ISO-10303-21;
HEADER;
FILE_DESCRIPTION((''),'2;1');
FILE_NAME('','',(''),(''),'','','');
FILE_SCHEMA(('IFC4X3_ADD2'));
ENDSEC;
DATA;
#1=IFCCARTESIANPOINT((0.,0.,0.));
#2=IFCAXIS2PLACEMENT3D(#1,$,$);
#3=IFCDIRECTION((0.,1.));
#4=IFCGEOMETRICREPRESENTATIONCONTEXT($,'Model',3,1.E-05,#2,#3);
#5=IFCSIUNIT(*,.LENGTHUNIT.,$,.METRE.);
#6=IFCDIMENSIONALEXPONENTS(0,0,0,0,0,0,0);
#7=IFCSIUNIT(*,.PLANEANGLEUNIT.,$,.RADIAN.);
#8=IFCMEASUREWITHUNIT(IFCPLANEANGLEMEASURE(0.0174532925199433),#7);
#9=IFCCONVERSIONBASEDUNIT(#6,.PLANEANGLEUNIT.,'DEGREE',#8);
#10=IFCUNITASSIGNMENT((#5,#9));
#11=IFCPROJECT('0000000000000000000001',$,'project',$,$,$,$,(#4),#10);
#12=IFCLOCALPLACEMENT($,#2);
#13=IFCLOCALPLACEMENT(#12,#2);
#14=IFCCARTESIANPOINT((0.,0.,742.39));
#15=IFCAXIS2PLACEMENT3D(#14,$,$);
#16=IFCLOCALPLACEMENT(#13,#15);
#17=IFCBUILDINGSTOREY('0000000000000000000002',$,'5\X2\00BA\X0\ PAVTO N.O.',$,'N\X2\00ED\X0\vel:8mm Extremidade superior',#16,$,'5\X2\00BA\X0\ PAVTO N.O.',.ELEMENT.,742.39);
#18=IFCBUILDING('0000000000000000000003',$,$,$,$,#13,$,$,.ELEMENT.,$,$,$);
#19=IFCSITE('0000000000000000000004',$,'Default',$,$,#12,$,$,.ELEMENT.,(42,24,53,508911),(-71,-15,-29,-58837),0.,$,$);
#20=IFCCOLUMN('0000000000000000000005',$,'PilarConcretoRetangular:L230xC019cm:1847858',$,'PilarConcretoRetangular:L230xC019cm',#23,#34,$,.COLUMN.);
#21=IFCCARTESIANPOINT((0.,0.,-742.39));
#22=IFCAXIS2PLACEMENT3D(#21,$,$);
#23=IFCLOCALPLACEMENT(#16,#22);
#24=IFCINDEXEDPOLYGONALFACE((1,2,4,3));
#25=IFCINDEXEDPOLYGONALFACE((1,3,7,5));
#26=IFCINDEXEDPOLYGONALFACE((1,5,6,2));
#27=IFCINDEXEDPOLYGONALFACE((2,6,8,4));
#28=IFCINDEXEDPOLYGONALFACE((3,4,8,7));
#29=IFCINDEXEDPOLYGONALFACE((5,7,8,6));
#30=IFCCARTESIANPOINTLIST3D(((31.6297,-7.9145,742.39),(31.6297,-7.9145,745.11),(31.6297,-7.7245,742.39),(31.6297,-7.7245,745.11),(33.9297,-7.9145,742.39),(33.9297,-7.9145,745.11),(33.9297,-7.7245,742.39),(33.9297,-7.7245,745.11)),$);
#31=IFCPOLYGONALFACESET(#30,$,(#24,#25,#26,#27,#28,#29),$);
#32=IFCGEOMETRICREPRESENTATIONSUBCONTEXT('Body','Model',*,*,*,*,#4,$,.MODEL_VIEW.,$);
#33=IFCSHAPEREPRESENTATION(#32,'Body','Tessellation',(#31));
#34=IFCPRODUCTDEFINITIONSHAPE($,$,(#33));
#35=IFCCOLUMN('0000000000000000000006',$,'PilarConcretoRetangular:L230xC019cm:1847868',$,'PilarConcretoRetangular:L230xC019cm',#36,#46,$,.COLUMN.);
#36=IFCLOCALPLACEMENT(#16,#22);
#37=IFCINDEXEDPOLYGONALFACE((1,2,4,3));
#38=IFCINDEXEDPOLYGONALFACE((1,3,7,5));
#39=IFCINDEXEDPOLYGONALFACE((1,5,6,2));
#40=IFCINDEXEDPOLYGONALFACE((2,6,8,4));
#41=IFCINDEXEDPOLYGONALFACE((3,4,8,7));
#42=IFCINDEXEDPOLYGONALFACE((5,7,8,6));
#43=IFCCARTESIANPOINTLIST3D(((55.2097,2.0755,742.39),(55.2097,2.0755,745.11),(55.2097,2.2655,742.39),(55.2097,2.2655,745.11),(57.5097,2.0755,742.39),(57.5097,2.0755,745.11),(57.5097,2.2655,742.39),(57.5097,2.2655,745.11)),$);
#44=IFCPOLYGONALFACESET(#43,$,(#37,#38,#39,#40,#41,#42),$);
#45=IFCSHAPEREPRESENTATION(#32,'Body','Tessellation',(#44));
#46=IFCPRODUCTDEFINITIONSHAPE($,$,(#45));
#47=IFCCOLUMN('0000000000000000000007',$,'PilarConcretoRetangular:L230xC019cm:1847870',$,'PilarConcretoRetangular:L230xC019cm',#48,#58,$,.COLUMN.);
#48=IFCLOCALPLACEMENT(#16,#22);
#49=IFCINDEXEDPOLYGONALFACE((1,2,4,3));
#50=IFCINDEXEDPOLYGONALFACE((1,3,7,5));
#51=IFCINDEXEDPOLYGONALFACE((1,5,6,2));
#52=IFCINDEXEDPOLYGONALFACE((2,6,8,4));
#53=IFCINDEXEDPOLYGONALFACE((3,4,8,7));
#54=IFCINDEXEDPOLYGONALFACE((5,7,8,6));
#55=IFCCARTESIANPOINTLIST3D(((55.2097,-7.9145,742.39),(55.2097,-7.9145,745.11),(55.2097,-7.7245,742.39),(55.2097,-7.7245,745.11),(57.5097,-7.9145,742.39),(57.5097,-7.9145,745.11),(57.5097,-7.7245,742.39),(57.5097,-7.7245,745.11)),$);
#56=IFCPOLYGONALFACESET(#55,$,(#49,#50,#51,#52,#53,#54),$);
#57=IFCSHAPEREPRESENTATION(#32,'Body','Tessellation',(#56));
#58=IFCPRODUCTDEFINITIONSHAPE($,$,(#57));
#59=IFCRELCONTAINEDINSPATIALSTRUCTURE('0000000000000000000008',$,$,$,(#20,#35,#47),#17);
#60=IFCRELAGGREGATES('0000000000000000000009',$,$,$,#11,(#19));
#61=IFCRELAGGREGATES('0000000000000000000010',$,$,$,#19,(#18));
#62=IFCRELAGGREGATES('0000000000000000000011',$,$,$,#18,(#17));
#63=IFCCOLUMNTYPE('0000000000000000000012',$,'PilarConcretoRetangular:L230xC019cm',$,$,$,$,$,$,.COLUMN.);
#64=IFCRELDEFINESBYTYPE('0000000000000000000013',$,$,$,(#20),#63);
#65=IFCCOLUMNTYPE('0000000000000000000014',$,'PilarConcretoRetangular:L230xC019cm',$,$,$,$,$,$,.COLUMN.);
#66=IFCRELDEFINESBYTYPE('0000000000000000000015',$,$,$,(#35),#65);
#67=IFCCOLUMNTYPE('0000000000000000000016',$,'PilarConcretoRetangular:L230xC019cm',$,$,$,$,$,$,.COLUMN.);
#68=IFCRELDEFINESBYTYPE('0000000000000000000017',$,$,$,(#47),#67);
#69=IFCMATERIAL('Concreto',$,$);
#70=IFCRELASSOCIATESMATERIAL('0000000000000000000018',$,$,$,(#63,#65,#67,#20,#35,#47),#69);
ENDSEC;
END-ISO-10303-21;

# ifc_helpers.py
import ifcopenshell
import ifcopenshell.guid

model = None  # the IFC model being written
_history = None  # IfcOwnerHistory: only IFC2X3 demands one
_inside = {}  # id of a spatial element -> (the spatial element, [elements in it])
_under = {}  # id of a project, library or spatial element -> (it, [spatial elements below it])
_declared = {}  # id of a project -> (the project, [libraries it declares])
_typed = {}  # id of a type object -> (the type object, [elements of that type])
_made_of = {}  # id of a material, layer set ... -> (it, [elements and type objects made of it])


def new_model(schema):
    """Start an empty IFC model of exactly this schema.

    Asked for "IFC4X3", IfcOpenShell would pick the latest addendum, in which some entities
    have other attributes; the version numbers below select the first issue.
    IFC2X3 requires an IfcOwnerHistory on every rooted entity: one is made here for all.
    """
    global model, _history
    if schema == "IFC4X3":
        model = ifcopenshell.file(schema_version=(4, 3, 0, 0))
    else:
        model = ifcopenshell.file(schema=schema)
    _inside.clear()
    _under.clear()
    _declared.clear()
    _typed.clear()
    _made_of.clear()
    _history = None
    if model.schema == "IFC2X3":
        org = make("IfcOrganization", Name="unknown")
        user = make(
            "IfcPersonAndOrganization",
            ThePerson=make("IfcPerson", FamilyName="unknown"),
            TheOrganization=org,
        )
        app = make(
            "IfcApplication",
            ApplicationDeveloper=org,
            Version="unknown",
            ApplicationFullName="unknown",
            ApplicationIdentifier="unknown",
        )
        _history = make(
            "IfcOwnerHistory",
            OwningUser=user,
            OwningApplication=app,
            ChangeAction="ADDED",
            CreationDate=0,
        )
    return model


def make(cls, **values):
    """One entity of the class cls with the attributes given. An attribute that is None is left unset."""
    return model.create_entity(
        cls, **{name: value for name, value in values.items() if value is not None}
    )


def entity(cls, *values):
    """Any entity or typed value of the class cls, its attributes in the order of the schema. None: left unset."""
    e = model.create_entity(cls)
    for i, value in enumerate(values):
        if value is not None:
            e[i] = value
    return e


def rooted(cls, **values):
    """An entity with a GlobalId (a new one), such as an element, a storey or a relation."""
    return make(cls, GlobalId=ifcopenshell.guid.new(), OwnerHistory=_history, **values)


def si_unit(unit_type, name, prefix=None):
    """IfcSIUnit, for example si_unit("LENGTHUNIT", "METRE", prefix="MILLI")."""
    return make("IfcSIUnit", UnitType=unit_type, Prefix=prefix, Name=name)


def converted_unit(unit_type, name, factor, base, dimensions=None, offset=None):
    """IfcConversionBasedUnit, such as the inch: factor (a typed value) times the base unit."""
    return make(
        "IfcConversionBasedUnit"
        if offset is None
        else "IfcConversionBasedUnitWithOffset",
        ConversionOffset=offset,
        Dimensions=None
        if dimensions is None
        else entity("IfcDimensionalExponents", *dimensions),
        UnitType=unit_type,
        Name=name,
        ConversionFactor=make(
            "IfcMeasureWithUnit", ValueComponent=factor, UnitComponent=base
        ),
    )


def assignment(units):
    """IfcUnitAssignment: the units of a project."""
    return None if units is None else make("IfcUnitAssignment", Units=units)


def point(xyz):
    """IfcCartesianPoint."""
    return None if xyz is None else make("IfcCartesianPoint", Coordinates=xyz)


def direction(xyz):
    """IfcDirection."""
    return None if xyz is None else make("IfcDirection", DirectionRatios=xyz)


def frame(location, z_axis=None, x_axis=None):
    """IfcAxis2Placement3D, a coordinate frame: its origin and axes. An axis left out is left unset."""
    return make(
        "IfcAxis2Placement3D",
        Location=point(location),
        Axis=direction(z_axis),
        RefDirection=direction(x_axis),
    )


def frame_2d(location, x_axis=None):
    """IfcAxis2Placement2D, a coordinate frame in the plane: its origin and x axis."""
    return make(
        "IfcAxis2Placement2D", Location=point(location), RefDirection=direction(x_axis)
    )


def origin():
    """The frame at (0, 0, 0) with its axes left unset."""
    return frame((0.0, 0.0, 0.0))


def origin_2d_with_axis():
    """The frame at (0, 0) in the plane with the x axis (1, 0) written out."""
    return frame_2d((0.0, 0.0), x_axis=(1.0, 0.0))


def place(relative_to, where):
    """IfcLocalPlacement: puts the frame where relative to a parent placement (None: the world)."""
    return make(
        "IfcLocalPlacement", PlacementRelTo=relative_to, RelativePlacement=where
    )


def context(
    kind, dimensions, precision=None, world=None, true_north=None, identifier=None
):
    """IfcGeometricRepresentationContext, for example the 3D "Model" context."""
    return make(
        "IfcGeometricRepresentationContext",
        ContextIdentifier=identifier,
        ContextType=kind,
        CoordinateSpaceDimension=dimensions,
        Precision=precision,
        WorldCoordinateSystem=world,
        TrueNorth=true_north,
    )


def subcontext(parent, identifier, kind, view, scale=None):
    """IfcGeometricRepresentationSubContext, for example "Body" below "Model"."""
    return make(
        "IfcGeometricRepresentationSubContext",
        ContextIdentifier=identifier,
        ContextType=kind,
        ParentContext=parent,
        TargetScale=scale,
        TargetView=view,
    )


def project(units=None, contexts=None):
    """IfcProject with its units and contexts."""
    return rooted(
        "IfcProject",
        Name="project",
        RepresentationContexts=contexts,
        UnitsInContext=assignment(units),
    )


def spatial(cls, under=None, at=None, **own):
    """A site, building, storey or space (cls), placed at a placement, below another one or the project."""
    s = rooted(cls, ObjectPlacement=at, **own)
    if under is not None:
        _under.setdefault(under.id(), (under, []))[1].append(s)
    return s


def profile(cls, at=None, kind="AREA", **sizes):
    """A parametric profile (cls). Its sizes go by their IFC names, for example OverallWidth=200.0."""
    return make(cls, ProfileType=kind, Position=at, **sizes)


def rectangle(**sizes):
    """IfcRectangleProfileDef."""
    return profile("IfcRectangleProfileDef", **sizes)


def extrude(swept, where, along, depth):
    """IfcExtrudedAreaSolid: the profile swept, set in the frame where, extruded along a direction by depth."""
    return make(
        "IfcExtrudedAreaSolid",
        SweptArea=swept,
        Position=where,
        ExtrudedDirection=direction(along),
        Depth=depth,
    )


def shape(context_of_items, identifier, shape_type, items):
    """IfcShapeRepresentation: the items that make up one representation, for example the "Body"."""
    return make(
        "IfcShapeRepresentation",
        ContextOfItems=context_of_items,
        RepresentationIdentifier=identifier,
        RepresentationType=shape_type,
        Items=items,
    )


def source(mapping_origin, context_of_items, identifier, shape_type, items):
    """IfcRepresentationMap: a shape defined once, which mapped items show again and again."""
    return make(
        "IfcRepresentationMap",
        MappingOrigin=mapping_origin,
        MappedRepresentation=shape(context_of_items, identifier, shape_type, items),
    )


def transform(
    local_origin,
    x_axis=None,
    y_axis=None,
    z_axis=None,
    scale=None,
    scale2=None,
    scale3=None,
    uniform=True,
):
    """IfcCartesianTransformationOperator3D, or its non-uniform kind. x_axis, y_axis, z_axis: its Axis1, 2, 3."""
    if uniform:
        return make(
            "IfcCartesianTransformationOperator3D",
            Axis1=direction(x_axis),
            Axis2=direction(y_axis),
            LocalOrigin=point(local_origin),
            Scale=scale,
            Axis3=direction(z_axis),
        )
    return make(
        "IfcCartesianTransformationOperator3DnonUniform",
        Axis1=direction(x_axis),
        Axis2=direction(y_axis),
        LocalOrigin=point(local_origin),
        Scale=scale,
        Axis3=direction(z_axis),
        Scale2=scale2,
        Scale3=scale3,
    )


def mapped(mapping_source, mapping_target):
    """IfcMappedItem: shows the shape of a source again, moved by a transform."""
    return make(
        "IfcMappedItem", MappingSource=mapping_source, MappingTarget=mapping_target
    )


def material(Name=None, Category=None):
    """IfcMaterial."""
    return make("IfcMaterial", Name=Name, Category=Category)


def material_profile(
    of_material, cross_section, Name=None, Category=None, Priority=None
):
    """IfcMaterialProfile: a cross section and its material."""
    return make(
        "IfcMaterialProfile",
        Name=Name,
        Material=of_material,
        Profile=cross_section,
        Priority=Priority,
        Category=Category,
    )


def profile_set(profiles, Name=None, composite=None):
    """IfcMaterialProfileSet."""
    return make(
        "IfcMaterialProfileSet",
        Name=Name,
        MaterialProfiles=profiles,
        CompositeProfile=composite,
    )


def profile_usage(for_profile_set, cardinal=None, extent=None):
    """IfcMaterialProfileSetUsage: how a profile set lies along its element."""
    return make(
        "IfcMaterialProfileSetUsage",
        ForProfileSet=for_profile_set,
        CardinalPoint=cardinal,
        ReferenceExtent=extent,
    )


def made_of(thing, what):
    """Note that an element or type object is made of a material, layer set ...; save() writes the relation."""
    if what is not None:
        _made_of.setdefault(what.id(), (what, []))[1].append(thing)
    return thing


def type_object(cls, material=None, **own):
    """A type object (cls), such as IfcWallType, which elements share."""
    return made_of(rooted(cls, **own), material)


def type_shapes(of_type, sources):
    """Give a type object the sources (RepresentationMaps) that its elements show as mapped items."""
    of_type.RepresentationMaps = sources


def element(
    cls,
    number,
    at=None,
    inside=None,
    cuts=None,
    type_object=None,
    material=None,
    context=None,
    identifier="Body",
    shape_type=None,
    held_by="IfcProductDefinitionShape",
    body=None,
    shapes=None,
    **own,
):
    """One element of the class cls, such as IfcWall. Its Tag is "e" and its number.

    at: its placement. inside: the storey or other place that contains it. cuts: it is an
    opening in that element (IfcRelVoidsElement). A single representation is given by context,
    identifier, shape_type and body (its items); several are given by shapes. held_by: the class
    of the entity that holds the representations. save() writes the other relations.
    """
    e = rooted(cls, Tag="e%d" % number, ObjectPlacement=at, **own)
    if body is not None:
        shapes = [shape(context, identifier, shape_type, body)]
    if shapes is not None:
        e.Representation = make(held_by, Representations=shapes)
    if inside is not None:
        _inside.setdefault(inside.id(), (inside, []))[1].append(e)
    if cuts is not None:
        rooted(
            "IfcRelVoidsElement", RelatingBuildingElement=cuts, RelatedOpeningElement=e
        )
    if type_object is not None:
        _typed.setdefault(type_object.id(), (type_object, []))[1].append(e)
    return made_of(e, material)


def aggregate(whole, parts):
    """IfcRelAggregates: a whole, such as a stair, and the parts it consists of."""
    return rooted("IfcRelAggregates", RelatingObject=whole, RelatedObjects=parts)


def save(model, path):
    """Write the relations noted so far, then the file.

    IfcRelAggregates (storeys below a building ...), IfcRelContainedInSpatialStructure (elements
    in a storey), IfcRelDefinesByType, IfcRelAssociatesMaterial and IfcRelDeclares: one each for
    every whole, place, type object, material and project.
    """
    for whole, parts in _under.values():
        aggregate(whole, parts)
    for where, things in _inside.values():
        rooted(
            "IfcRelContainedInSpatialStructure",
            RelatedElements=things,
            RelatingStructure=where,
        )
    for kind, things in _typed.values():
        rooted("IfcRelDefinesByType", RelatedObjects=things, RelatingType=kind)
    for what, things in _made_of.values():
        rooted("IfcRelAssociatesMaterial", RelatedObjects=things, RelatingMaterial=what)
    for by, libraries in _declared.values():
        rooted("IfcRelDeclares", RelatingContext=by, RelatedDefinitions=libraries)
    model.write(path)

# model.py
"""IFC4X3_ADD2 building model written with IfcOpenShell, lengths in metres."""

from ifc_helpers import new_model, entity, si_unit, converted_unit, direction, frame, frame_2d, origin, origin_2d_with_axis, place, context, subcontext, project, spatial, rectangle, extrude, source, transform, mapped, material, material_profile, profile_set, profile_usage, type_object, type_shapes, element, save


model = new_model("IFC4X3_ADD2")

# Units and contexts
model_context = context("Model", 3, precision=1e-05, world=origin(), true_north=direction((0.0, 1.0)))
body_context = subcontext(model_context, "Body", "Model", "MODEL_VIEW")
ifc_project = project(units=[si_unit("LENGTHUNIT", "METRE"), converted_unit("PLANEANGLEUNIT", "DEGREE", entity("IfcPlaneAngleMeasure", 0.0174532925199433), si_unit("PLANEANGLEUNIT", "RADIAN"), dimensions=[0, 0, 0, 0, 0, 0, 0])], contexts=[model_context])

# Site, building, storey
site_placement = place(None, origin())
site = spatial("IfcSite", under=ifc_project, at=site_placement, Name="Default", CompositionType="ELEMENT", RefLatitude=(42, 24, 53, 508911), RefLongitude=(-71, -15, -29, -58837), RefElevation=0.0)
building_placement = place(site_placement, origin())
building = spatial("IfcBuilding", under=site, at=building_placement, CompositionType="ELEMENT")
storey_placement = place(building_placement, frame((0.0, 0.0, 742.39)))
storey = spatial("IfcBuildingStorey", under=building, at=storey_placement, Name="5º PAVTO N.O.", ObjectType="Nível:8mm Extremidade superior", LongName="5º PAVTO N.O.", CompositionType="ELEMENT", Elevation=742.39)

# Columns
ifc_material = material(Name="Concreto")
ifc_material_profile_1 = material_profile(ifc_material, rectangle(XDim=2.3, YDim=0.19, at=frame_2d((0.192, 0.019), x_axis=(1.0, 0.0))), Name="L230xC019cm")
ifc_profile_set_1 = profile_set([ifc_material_profile_1], Name="L230xC019cm")
ifc_profile_usage_1 = profile_usage(ifc_profile_set_1)
column_type_1 = type_object("IfcColumnType", Name="PilarConcretoRetangular:L230xC019cm", PredefinedType="COLUMN", material=ifc_profile_set_1)
shared_shape_1 = source(origin(), body_context, "Body", "SweptSolid", [
    extrude(rectangle(XDim=2.3, YDim=0.19, at=frame_2d((0.0, 0.0), x_axis=(1.0, 0.0))), frame((32.7797, -7.8195, 742.39)), (0.0, 0.0, 1.0), 2.72),
])
type_shapes(column_type_1, [shared_shape_1])
column_1_placement = place(storey_placement, frame((0.0, 0.0, -742.39)))
element("IfcColumn", 1, at=column_1_placement, inside=storey, type_object=column_type_1, material=ifc_profile_usage_1, Name="PilarConcretoRetangular:L230xC019cm:1847858", ObjectType="PilarConcretoRetangular:L230xC019cm", PredefinedType="COLUMN", context=body_context, shape_type="MappedRepresentation", body=[
    mapped(shared_shape_1, transform((0.0, 0.0, 0.0), scale=1.0)),
])
column_type_2 = type_object("IfcColumnType", Name="PilarConcretoRetangular:L230xC019cm", PredefinedType="COLUMN", material=ifc_profile_set_1)
shared_shape_2 = source(origin(), body_context, "Body", "SweptSolid", [
    extrude(rectangle(XDim=2.3, YDim=0.19, at=origin_2d_with_axis()), frame((56.3597, 2.1705, 742.39), z_axis=(0.0, 0.0, 1.0), x_axis=(-1.0, 0.0, 0.0)), (0.0, 0.0, 1.0), 2.72),
])
type_shapes(column_type_2, [shared_shape_2])
column_2_placement = place(storey_placement, frame((0.0, 0.0, -742.39)))
element("IfcColumn", 2, at=column_2_placement, inside=storey, type_object=column_type_2, material=ifc_profile_usage_1, Name="PilarConcretoRetangular:L230xC019cm:1847868", ObjectType="PilarConcretoRetangular:L230xC019cm", PredefinedType="COLUMN", context=body_context, shape_type="MappedRepresentation", body=[
    mapped(shared_shape_2, transform((0.0, 0.0, 0.0), scale=1.0)),
])
column_type_3 = type_object("IfcColumnType", Name="PilarConcretoRetangular:L230xC019cm", PredefinedType="COLUMN", material=ifc_profile_set_1)
shared_shape_3 = source(origin(), body_context, "Body", "SweptSolid", [
    extrude(rectangle(XDim=2.3, YDim=0.19, at=origin_2d_with_axis()), frame((56.3597, -7.8195, 742.39), z_axis=(0.0, 0.0, 1.0), x_axis=(-1.0, 0.0, 0.0)), (0.0, 0.0, 1.0), 2.72),
])
type_shapes(column_type_3, [shared_shape_3])
column_3_placement = place(storey_placement, frame((0.0, 0.0, -742.39)))
element("IfcColumn", 3, at=column_3_placement, inside=storey, type_object=column_type_3, material=ifc_profile_usage_1, Name="PilarConcretoRetangular:L230xC019cm:1847870", ObjectType="PilarConcretoRetangular:L230xC019cm", PredefinedType="COLUMN", context=body_context, shape_type="MappedRepresentation", body=[
    mapped(shared_shape_3, transform((0.0, 0.0, 0.0), scale=1.0)),
])

save(model, "model.ifc")
